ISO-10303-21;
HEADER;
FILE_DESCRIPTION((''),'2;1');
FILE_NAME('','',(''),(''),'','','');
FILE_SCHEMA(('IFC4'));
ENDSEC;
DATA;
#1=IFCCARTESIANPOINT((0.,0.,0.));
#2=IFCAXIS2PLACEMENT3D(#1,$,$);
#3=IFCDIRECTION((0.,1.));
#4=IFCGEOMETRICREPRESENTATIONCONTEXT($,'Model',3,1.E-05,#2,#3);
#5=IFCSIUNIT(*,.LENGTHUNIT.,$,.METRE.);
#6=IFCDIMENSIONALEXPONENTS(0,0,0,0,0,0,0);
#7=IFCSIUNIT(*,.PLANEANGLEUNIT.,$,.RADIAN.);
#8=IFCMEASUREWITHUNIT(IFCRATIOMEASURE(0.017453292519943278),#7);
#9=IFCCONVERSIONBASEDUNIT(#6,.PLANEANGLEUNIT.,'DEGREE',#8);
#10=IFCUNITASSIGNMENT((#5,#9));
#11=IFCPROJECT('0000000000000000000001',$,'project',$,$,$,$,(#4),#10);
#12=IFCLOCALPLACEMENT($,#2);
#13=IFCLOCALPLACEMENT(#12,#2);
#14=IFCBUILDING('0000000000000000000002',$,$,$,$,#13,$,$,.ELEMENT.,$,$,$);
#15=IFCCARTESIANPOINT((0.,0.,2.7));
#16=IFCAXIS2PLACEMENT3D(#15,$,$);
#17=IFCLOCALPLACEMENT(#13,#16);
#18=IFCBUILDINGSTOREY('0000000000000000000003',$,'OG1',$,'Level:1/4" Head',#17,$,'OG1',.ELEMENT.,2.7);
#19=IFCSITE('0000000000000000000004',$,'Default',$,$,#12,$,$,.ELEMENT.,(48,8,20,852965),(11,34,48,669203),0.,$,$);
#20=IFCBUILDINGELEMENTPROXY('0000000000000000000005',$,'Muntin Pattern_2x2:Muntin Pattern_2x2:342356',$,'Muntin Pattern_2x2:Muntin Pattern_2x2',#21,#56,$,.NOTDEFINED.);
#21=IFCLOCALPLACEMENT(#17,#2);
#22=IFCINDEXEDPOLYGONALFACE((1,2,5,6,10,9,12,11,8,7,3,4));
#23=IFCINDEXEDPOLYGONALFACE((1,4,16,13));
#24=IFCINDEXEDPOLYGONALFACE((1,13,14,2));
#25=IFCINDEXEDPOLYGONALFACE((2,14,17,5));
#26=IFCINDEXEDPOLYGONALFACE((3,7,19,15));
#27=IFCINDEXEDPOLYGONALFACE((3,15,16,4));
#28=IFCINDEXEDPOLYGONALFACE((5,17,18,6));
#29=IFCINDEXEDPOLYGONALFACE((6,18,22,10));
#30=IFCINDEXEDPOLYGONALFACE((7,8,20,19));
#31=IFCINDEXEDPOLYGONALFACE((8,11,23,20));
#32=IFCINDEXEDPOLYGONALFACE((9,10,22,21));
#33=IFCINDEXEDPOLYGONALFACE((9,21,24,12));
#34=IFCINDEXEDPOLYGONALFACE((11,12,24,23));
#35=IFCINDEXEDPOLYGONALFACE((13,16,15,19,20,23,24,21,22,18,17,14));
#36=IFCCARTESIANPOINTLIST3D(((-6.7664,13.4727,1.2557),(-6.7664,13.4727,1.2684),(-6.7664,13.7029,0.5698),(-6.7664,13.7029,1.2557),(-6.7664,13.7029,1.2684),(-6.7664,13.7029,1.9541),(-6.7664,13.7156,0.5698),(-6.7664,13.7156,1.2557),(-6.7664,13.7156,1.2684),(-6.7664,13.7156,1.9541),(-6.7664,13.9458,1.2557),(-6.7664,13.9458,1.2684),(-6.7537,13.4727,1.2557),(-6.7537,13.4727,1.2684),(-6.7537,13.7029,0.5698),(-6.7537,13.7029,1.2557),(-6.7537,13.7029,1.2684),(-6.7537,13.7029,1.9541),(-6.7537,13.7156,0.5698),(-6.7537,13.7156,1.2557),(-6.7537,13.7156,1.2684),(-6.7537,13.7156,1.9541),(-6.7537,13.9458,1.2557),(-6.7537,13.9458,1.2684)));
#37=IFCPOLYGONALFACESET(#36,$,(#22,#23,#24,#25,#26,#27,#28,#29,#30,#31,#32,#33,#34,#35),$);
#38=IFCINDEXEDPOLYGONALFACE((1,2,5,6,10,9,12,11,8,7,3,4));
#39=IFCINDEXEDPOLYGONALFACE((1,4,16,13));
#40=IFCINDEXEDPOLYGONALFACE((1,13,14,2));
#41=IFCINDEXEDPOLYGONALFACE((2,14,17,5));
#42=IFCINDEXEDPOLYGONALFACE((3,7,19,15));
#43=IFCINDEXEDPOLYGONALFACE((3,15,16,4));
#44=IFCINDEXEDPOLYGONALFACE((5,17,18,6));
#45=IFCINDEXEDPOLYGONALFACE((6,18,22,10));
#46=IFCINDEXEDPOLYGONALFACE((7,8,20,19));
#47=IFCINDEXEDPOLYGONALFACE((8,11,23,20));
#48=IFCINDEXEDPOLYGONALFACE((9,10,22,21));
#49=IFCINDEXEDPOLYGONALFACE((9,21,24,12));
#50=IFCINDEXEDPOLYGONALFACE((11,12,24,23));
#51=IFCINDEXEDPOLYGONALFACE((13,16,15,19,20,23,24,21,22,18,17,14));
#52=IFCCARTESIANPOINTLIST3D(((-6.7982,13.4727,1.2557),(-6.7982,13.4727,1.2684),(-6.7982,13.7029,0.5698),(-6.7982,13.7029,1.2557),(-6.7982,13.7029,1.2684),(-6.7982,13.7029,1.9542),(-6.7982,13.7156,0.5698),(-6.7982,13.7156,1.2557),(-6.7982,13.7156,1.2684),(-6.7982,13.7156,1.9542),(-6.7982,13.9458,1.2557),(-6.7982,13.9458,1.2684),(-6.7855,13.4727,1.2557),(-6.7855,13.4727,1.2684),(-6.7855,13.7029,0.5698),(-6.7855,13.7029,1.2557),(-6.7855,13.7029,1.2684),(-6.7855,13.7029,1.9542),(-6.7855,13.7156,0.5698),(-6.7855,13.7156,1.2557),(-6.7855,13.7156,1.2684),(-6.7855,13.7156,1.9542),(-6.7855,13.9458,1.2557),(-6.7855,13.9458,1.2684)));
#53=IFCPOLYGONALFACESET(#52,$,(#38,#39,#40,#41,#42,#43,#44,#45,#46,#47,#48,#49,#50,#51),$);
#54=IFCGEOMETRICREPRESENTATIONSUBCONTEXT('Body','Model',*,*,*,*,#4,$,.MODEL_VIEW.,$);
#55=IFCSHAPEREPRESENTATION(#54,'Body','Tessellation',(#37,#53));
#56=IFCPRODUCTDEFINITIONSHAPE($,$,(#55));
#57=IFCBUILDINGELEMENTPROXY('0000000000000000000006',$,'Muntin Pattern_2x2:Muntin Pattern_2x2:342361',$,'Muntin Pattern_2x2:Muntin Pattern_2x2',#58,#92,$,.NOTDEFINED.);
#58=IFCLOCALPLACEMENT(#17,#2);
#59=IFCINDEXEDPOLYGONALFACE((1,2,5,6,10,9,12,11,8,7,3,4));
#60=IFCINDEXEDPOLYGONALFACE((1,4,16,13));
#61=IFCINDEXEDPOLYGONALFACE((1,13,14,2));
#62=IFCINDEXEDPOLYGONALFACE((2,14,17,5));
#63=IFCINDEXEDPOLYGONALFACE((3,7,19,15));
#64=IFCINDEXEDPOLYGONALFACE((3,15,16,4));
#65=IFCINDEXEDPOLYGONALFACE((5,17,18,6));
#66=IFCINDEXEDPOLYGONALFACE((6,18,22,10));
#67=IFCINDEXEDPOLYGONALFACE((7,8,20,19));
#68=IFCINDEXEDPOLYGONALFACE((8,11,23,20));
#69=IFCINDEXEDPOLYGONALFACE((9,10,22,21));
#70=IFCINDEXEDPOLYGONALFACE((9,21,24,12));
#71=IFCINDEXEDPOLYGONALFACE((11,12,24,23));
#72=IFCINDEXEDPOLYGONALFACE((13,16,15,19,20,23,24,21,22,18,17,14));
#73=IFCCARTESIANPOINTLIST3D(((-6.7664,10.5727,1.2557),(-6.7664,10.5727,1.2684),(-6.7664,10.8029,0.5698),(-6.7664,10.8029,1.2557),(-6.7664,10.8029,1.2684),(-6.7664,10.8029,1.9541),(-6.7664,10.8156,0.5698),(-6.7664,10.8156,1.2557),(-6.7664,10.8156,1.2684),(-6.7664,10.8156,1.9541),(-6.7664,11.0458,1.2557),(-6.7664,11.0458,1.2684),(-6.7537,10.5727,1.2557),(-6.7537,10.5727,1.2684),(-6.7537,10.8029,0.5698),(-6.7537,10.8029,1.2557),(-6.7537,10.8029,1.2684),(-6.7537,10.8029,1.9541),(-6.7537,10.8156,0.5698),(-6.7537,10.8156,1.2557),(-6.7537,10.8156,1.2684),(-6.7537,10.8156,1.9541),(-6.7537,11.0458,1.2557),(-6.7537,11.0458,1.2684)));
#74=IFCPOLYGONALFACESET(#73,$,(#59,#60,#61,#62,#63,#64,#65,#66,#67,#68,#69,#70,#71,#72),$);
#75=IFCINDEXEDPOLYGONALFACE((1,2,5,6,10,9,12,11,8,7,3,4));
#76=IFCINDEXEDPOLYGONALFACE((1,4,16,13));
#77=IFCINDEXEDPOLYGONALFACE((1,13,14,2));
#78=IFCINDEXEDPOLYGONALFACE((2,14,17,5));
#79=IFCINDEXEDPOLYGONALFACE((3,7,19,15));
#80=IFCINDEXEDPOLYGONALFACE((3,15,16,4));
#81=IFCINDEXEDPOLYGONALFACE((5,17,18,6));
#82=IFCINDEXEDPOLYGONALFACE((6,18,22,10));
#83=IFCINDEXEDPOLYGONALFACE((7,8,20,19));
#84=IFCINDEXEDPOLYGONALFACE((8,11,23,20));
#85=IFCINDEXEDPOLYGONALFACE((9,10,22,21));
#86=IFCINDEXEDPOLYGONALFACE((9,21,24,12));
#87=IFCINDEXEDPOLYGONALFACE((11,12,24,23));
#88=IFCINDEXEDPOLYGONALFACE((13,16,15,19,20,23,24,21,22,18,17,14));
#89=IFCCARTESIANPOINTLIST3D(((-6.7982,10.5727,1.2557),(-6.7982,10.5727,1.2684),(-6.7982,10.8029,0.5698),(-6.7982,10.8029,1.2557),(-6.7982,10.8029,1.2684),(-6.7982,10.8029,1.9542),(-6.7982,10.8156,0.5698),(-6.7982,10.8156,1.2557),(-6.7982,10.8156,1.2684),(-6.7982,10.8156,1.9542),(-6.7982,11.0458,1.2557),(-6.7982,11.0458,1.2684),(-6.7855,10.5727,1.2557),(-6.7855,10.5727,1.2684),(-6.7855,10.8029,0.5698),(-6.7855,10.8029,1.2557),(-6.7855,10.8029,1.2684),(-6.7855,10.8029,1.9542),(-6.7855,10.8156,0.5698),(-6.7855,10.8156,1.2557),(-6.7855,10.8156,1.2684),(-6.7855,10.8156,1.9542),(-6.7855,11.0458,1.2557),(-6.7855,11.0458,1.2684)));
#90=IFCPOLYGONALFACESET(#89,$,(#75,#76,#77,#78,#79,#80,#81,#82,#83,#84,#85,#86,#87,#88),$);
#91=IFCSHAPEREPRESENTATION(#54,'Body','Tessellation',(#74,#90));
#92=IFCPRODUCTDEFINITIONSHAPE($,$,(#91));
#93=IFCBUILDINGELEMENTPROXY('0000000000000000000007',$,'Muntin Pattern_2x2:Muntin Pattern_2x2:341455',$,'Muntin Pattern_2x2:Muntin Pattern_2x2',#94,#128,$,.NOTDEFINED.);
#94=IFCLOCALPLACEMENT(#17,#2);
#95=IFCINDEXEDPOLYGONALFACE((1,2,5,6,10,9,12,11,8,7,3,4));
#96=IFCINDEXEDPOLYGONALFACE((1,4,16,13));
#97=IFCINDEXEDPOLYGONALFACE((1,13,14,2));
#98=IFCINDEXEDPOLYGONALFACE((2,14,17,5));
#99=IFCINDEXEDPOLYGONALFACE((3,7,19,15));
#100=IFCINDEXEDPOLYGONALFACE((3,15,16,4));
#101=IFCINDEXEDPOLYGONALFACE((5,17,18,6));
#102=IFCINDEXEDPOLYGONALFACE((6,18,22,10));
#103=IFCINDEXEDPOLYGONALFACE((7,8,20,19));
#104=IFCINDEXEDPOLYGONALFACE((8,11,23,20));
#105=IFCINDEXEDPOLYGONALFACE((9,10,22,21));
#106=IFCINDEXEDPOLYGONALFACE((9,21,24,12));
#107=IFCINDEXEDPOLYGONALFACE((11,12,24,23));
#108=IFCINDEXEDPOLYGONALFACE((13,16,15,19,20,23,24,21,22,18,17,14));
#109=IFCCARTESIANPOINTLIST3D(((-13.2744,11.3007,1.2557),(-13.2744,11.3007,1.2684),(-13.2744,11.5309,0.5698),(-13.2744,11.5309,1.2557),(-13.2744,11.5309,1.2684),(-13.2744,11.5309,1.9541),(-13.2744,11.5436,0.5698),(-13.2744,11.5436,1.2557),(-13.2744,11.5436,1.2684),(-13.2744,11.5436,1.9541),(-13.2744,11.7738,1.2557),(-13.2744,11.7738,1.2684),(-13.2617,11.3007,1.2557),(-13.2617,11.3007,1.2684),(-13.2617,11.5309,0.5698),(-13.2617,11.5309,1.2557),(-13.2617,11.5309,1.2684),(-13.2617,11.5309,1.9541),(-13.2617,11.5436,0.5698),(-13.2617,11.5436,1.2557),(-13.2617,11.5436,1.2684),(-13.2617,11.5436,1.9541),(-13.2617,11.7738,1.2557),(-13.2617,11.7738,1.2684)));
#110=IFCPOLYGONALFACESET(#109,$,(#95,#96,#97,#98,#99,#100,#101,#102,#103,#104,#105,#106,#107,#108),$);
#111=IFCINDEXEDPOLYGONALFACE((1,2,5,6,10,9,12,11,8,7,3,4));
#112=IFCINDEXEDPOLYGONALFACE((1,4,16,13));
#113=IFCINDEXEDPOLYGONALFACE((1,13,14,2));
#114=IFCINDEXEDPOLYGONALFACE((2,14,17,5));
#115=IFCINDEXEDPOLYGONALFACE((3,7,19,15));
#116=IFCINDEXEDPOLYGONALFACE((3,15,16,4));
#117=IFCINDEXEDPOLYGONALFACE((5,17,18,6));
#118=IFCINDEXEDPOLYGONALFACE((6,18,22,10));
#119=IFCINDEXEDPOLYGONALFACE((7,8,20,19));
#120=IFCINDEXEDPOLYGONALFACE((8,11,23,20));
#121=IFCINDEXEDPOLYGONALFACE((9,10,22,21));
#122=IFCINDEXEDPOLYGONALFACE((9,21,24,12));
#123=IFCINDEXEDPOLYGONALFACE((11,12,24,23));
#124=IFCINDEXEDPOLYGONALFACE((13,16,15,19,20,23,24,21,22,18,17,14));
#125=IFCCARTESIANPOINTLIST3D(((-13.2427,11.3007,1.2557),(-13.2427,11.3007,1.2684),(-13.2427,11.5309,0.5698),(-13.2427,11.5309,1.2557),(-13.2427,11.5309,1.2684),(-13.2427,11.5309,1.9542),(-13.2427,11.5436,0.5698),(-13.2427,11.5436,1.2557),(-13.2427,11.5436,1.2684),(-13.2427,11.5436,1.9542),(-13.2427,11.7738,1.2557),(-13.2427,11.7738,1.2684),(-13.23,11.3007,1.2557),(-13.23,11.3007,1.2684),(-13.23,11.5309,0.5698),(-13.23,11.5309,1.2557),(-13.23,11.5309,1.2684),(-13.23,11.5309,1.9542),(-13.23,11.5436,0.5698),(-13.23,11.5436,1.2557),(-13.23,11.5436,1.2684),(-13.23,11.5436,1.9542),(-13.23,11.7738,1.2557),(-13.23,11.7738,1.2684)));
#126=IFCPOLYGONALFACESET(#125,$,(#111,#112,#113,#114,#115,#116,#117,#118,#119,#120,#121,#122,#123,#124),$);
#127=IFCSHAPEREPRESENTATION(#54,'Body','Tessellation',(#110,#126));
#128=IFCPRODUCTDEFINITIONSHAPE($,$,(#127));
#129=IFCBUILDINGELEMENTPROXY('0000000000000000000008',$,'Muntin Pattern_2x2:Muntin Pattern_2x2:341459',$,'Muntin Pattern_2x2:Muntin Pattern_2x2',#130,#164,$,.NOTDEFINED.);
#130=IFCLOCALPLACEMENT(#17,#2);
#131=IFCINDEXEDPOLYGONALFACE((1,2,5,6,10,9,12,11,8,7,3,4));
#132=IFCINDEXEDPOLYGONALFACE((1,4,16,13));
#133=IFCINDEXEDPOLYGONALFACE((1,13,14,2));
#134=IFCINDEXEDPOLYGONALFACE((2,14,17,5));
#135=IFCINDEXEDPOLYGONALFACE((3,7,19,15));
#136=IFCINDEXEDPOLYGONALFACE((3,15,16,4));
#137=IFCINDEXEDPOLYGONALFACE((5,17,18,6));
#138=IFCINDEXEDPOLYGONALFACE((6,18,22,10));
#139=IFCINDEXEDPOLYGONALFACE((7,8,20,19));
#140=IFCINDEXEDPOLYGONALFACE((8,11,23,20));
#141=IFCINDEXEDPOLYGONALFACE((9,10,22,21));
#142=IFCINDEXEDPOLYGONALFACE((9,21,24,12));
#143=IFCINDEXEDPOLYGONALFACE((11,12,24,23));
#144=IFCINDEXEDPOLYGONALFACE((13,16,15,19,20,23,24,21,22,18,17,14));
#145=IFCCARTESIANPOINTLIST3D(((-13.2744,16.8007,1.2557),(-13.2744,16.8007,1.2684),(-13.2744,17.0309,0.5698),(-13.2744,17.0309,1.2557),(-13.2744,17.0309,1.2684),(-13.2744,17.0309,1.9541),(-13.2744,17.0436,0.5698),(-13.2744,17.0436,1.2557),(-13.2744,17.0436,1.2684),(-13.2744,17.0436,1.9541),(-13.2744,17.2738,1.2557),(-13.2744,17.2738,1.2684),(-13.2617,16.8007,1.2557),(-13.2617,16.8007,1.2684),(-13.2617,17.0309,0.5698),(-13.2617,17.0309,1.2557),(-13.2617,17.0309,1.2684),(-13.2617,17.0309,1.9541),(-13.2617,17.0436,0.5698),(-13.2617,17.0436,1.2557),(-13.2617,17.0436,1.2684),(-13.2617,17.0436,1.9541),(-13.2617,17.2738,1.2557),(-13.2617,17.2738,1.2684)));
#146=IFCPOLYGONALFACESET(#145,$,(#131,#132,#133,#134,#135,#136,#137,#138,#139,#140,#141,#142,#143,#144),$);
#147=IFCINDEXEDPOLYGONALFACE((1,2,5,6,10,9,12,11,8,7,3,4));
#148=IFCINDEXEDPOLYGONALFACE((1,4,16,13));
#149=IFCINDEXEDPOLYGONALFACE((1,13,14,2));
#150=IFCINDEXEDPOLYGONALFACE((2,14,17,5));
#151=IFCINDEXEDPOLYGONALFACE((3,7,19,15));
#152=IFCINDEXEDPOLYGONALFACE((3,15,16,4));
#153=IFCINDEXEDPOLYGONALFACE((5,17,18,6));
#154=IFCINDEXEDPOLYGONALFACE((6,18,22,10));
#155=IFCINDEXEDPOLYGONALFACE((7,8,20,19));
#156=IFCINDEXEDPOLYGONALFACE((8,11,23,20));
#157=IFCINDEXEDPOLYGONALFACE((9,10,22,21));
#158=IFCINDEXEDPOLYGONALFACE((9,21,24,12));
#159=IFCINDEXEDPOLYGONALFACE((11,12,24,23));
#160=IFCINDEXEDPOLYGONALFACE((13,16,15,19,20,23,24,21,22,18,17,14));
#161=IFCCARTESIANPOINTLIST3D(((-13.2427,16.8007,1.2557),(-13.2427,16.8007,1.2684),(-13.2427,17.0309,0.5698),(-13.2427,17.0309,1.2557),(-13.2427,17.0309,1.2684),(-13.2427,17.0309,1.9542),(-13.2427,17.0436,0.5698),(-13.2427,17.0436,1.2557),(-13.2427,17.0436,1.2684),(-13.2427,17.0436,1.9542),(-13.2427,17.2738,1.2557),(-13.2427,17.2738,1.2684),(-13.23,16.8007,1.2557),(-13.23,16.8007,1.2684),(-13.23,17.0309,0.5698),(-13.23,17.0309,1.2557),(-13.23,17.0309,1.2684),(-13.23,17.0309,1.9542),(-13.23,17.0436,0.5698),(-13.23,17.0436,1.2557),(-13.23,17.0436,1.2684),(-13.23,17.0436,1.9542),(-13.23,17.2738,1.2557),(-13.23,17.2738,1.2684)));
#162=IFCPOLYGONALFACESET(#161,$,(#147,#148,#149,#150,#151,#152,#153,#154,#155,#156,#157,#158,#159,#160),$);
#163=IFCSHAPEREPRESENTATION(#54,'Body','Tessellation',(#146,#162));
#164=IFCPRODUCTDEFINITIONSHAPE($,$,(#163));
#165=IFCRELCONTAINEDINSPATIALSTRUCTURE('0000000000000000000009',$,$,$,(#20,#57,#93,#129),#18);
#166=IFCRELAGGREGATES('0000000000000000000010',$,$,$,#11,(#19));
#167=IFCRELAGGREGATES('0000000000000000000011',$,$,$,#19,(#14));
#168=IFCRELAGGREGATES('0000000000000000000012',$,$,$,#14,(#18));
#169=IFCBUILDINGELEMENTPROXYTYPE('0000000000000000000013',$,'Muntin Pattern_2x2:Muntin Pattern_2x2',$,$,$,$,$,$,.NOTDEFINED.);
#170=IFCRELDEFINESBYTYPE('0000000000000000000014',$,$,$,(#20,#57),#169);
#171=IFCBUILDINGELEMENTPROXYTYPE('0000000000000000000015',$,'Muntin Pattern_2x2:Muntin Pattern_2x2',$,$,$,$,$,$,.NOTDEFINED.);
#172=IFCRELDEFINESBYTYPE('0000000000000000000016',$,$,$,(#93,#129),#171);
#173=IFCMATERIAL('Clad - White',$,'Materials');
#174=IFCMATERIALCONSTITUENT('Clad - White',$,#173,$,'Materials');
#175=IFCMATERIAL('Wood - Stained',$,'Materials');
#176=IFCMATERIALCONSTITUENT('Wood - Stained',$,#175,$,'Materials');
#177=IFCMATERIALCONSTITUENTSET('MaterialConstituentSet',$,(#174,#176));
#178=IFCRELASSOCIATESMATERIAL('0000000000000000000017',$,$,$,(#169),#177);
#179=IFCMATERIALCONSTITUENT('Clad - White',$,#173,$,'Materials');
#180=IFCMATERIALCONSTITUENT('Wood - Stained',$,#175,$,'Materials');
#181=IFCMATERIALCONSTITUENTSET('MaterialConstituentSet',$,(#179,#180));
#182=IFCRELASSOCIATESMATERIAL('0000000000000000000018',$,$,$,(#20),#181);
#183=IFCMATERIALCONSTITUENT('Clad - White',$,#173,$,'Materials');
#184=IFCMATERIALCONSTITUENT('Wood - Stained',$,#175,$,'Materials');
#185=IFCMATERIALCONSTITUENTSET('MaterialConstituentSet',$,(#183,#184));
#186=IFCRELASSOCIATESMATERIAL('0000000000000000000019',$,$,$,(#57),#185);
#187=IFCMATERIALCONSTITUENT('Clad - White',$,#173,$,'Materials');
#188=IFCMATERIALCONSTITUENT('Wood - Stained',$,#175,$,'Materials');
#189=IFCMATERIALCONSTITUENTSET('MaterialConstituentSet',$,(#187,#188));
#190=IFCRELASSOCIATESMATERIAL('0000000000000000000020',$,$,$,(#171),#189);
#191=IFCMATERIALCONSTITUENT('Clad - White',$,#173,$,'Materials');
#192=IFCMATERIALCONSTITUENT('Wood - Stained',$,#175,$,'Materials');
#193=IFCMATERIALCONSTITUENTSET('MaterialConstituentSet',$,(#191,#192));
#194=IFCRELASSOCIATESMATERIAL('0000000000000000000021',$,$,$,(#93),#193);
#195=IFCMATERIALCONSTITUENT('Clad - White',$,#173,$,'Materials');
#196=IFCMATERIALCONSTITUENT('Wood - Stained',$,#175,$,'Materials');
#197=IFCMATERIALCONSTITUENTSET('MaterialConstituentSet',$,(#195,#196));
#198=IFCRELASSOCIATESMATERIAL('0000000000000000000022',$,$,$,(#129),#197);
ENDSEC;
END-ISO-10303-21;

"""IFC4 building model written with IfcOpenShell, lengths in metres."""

from ifc_helpers import new_model, entity, si_unit, converted_unit, direction, frame, origin, place, context, subcontext, project, spatial, indexed_curve, outline, extrude, source, transform, mapped, material, constituent, constituent_set, type_object, type_shapes, element, save


model = new_model("IFC4")

# Units and contexts
model_context = context("Model", 3, precision=1e-05, world=origin(), true_north=direction((0.0, 1.0)))
body_context = subcontext(model_context, "Body", "Model", "MODEL_VIEW")
ifc_project = project(units=[si_unit("LENGTHUNIT", "METRE"), converted_unit("PLANEANGLEUNIT", "DEGREE", entity("IfcRatioMeasure", 0.017453292519943278), si_unit("PLANEANGLEUNIT", "RADIAN"), dimensions=[0, 0, 0, 0, 0, 0, 0])], contexts=[model_context])

# Site, building, storey
site_placement = place(None, origin())
site = spatial("IfcSite", under=ifc_project, at=site_placement, Name="Default", CompositionType="ELEMENT", RefLatitude=(48, 8, 20, 852965), RefLongitude=(11, 34, 48, 669203), RefElevation=0.0)
building_placement = place(site_placement, origin())
building = spatial("IfcBuilding", under=site, at=building_placement, CompositionType="ELEMENT")
storey_placement = place(building_placement, frame((0.0, 0.0, 2.7)))
storey = spatial("IfcBuildingStorey", under=building, at=storey_placement, Name="OG1", ObjectType="Level:1/4\" Head", LongName="OG1", CompositionType="ELEMENT", Elevation=2.7)

# Building element proxies
ifc_material_1 = material(Name="Clad - White", Category="Materials")
ifc_material_2 = material(Name="Wood - Stained", Category="Materials")
ifc_constituent_1 = constituent(ifc_material_1, Name="Clad - White", Category="Materials")
ifc_constituent_2 = constituent(ifc_material_2, Name="Wood - Stained", Category="Materials")
ifc_constituent_set_1 = constituent_set(constituents=[ifc_constituent_1, ifc_constituent_2], Name="MaterialConstituentSet")
building_element_proxy_type_1 = type_object("IfcBuildingElementProxyType", Name="Muntin Pattern_2x2:Muntin Pattern_2x2", PredefinedType="NOTDEFINED", material=ifc_constituent_set_1)
shared_shape_1 = source(origin(), body_context, "Body", "SweptSolid", [
    extrude(outline(indexed_curve([(0.0064, -0.0064), (0.6921, -0.0064), (0.6921, 0.0063), (0.0064, 0.0063), (0.0064, 0.2365), (-0.0063, 0.2365), (-0.0063, 0.0063), (-0.6922, 0.0063), (-0.6922, -0.0064), (-0.0063, -0.0064), (-0.0063, -0.2365), (0.0064, -0.2365), (0.0064, -0.0064)], self_intersect=False)), frame((0.0, -0.0222, 0.6921), z_axis=(0.0, 1.0, 0.0), x_axis=(0.0, 0.0, 1.0)), (0.0, 0.0, 1.0), 0.0127),
    extrude(outline(indexed_curve([(0.0064, -0.0064), (0.6922, -0.0064), (0.6922, 0.0063), (0.0064, 0.0063), (0.0064, 0.2365), (-0.0063, 0.2365), (-0.0063, 0.0063), (-0.6922, 0.0063), (-0.6922, -0.0064), (-0.0063, -0.0064), (-0.0063, -0.2365), (0.0064, -0.2365), (0.0064, -0.0064)], self_intersect=False)), frame((0.0, 0.0095, 0.6922), z_axis=(0.0, 1.0, 0.0), x_axis=(0.0, 0.0, 1.0)), (0.0, 0.0, 1.0), 0.0127),
])
type_shapes(building_element_proxy_type_1, [shared_shape_1])
ifc_constituent_3 = constituent(ifc_material_1, Name="Clad - White", Category="Materials")
ifc_constituent_4 = constituent(ifc_material_2, Name="Wood - Stained", Category="Materials")
ifc_constituent_set_2 = constituent_set(constituents=[ifc_constituent_3, ifc_constituent_4], Name="MaterialConstituentSet")
proxy_1_placement = place(storey_placement, frame((-6.7759, 13.7093, 0.5699), z_axis=(0.0, 0.0, 1.0), x_axis=(0.0, 1.0, 0.0)))
element("IfcBuildingElementProxy", 1, at=proxy_1_placement, inside=storey, type_object=building_element_proxy_type_1, material=ifc_constituent_set_2, Name="Muntin Pattern_2x2:Muntin Pattern_2x2:342356", ObjectType="Muntin Pattern_2x2:Muntin Pattern_2x2", PredefinedType="NOTDEFINED", context=body_context, shape_type="MappedRepresentation", body=[
    mapped(shared_shape_1, transform((0.0, 0.0, 0.0), scale=1.0)),
])
ifc_constituent_5 = constituent(ifc_material_1, Name="Clad - White", Category="Materials")
ifc_constituent_6 = constituent(ifc_material_2, Name="Wood - Stained", Category="Materials")
ifc_constituent_set_3 = constituent_set(constituents=[ifc_constituent_5, ifc_constituent_6], Name="MaterialConstituentSet")
proxy_2_placement = place(storey_placement, frame((-6.7759, 10.8093, 0.5699), z_axis=(0.0, 0.0, 1.0), x_axis=(0.0, 1.0, 0.0)))
element("IfcBuildingElementProxy", 2, at=proxy_2_placement, inside=storey, type_object=building_element_proxy_type_1, material=ifc_constituent_set_3, Name="Muntin Pattern_2x2:Muntin Pattern_2x2:342361", ObjectType="Muntin Pattern_2x2:Muntin Pattern_2x2", PredefinedType="NOTDEFINED", context=body_context, shape_type="MappedRepresentation", body=[
    mapped(shared_shape_1, transform((0.0, 0.0, 0.0), scale=1.0)),
])
ifc_constituent_7 = constituent(ifc_material_1, Name="Clad - White", Category="Materials")
ifc_constituent_8 = constituent(ifc_material_2, Name="Wood - Stained", Category="Materials")
ifc_constituent_set_4 = constituent_set(constituents=[ifc_constituent_7, ifc_constituent_8], Name="MaterialConstituentSet")
ifc_constituent_9 = constituent(ifc_material_1, Name="Clad - White", Category="Materials")
ifc_constituent_10 = constituent(ifc_material_2, Name="Wood - Stained", Category="Materials")
ifc_constituent_set_5 = constituent_set(constituents=[ifc_constituent_9, ifc_constituent_10], Name="MaterialConstituentSet")
building_element_proxy_type_2 = type_object("IfcBuildingElementProxyType", Name="Muntin Pattern_2x2:Muntin Pattern_2x2", PredefinedType="NOTDEFINED", material=ifc_constituent_set_5)
shared_shape_2 = source(origin(), body_context, "Body", "SweptSolid", [
    extrude(outline(indexed_curve([(0.0064, -0.0064), (0.6921, -0.0064), (0.6921, 0.0063), (0.0064, 0.0063), (0.0064, 0.2365), (-0.0063, 0.2365), (-0.0063, 0.0063), (-0.6922, 0.0063), (-0.6922, -0.0064), (-0.0063, -0.0064), (-0.0063, -0.2365), (0.0064, -0.2365), (0.0064, -0.0064)], self_intersect=False)), frame((0.0, 0.0095, 0.6921), z_axis=(0.0, 1.0, 0.0), x_axis=(0.0, 0.0, 1.0)), (0.0, 0.0, 1.0), 0.0127),
    extrude(outline(indexed_curve([(0.0064, -0.0064), (0.6922, -0.0064), (0.6922, 0.0063), (0.0064, 0.0063), (0.0064, 0.2365), (-0.0063, 0.2365), (-0.0063, 0.0063), (-0.6922, 0.0063), (-0.6922, -0.0064), (-0.0063, -0.0064), (-0.0063, -0.2365), (0.0064, -0.2365), (0.0064, -0.0064)], self_intersect=False)), frame((0.0, -0.0222, 0.6922), z_axis=(0.0, 1.0, 0.0), x_axis=(0.0, 0.0, 1.0)), (0.0, 0.0, 1.0), 0.0127),
])
type_shapes(building_element_proxy_type_2, [shared_shape_2])
proxy_3_placement = place(storey_placement, frame((-13.2522, 11.5372, 0.5699), z_axis=(0.0, 0.0, 1.0), x_axis=(0.0, 1.0, 0.0)))
element("IfcBuildingElementProxy", 3, at=proxy_3_placement, inside=storey, type_object=building_element_proxy_type_2, material=ifc_constituent_set_4, Name="Muntin Pattern_2x2:Muntin Pattern_2x2:341455", ObjectType="Muntin Pattern_2x2:Muntin Pattern_2x2", PredefinedType="NOTDEFINED", context=body_context, shape_type="MappedRepresentation", body=[
    mapped(shared_shape_2, transform((0.0, 0.0, 0.0), scale=1.0)),
])
ifc_constituent_11 = constituent(ifc_material_1, Name="Clad - White", Category="Materials")
ifc_constituent_12 = constituent(ifc_material_2, Name="Wood - Stained", Category="Materials")
ifc_constituent_set_6 = constituent_set(constituents=[ifc_constituent_11, ifc_constituent_12], Name="MaterialConstituentSet")
proxy_4_placement = place(storey_placement, frame((-13.2522, 17.0372, 0.5699), z_axis=(0.0, 0.0, 1.0), x_axis=(0.0, 1.0, 0.0)))
element("IfcBuildingElementProxy", 4, at=proxy_4_placement, inside=storey, type_object=building_element_proxy_type_2, material=ifc_constituent_set_6, Name="Muntin Pattern_2x2:Muntin Pattern_2x2:341459", ObjectType="Muntin Pattern_2x2:Muntin Pattern_2x2", PredefinedType="NOTDEFINED", context=body_context, shape_type="MappedRepresentation", body=[
    mapped(shared_shape_2, transform((0.0, 0.0, 0.0), scale=1.0)),
])

save(model, "model.ifc")
